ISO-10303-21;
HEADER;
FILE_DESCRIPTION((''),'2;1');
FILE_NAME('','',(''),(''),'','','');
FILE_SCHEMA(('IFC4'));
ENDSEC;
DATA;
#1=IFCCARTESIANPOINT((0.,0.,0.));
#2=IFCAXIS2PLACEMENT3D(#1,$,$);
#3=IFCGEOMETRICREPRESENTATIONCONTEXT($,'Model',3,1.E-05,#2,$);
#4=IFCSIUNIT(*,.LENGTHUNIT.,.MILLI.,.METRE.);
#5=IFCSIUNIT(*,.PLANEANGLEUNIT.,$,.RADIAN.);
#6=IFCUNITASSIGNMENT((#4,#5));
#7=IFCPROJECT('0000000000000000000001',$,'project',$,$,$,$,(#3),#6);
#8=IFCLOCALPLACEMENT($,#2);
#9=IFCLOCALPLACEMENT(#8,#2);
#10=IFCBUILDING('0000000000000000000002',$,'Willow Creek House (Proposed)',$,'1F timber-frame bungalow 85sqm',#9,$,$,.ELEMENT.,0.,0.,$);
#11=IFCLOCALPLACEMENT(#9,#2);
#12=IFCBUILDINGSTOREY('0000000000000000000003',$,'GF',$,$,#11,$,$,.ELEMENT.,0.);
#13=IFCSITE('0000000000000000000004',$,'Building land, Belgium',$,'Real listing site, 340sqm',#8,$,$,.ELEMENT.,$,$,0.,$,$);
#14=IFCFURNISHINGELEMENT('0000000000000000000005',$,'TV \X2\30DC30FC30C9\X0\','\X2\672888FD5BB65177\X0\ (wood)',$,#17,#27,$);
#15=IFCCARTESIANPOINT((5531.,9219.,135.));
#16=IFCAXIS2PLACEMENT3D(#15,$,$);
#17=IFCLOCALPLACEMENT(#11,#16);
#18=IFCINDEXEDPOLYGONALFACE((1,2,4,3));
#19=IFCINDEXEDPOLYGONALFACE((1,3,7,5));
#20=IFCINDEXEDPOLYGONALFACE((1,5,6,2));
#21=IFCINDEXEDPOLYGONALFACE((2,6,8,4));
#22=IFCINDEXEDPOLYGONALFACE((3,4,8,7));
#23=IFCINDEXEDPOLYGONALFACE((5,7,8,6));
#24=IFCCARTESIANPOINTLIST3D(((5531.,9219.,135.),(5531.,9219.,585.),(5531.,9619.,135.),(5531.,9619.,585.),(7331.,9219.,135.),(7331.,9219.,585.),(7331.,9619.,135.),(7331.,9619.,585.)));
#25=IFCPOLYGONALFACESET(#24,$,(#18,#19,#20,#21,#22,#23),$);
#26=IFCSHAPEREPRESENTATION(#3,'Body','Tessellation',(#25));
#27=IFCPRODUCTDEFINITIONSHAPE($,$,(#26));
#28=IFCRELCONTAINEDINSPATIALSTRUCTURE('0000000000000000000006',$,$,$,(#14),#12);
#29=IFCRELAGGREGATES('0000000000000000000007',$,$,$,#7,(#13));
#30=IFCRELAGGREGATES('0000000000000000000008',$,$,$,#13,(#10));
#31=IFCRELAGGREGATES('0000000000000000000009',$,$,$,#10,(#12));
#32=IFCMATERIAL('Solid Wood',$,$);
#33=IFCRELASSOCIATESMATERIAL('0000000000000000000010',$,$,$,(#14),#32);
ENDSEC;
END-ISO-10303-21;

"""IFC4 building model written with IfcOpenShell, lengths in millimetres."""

from ifc_helpers import new_model, si_unit, frame, frame_2d, origin, place, context, project, spatial, rectangle, extrude, material, element, save


model = new_model("IFC4")

# Units and contexts
model_context = context("Model", 3, precision=1e-05, world=origin())
ifc_project = project(units=[si_unit("LENGTHUNIT", "METRE", prefix="MILLI"), si_unit("PLANEANGLEUNIT", "RADIAN")], contexts=[model_context])

# Site, building, storey
site_placement = place(None, origin())
site = spatial("IfcSite", under=ifc_project, at=site_placement, Name="Building land, Belgium", ObjectType="Real listing site, 340sqm", CompositionType="ELEMENT", RefElevation=0.0)
building_placement = place(site_placement, origin())
building = spatial("IfcBuilding", under=site, at=building_placement, Name="Willow Creek House (Proposed)", ObjectType="1F timber-frame bungalow 85sqm", CompositionType="ELEMENT", ElevationOfRefHeight=0.0, ElevationOfTerrain=0.0)
storey_placement = place(building_placement, origin())
storey = spatial("IfcBuildingStorey", under=building, at=storey_placement, Name="GF", CompositionType="ELEMENT", Elevation=0.0)

# Shared definitions
ifc_material_1 = material(Name="Solid Wood")

# Furnishing element
furnishing_1_placement = place(storey_placement, frame((5531.0, 9219.0, 135.0)))
element("IfcFurnishingElement", 1, at=furnishing_1_placement, inside=storey, material=ifc_material_1, Name="TV ボード", Description="木製家具 (wood)", context=model_context, shape_type="SweptSolid", body=[
    extrude(rectangle(XDim=1800.0, YDim=400.0, at=frame_2d((900.0, 200.0))), frame((5531.0, 9219.0, 135.0)), (0.0, 0.0, 1.0), 450.0),
])

save(model, "model.ifc")
